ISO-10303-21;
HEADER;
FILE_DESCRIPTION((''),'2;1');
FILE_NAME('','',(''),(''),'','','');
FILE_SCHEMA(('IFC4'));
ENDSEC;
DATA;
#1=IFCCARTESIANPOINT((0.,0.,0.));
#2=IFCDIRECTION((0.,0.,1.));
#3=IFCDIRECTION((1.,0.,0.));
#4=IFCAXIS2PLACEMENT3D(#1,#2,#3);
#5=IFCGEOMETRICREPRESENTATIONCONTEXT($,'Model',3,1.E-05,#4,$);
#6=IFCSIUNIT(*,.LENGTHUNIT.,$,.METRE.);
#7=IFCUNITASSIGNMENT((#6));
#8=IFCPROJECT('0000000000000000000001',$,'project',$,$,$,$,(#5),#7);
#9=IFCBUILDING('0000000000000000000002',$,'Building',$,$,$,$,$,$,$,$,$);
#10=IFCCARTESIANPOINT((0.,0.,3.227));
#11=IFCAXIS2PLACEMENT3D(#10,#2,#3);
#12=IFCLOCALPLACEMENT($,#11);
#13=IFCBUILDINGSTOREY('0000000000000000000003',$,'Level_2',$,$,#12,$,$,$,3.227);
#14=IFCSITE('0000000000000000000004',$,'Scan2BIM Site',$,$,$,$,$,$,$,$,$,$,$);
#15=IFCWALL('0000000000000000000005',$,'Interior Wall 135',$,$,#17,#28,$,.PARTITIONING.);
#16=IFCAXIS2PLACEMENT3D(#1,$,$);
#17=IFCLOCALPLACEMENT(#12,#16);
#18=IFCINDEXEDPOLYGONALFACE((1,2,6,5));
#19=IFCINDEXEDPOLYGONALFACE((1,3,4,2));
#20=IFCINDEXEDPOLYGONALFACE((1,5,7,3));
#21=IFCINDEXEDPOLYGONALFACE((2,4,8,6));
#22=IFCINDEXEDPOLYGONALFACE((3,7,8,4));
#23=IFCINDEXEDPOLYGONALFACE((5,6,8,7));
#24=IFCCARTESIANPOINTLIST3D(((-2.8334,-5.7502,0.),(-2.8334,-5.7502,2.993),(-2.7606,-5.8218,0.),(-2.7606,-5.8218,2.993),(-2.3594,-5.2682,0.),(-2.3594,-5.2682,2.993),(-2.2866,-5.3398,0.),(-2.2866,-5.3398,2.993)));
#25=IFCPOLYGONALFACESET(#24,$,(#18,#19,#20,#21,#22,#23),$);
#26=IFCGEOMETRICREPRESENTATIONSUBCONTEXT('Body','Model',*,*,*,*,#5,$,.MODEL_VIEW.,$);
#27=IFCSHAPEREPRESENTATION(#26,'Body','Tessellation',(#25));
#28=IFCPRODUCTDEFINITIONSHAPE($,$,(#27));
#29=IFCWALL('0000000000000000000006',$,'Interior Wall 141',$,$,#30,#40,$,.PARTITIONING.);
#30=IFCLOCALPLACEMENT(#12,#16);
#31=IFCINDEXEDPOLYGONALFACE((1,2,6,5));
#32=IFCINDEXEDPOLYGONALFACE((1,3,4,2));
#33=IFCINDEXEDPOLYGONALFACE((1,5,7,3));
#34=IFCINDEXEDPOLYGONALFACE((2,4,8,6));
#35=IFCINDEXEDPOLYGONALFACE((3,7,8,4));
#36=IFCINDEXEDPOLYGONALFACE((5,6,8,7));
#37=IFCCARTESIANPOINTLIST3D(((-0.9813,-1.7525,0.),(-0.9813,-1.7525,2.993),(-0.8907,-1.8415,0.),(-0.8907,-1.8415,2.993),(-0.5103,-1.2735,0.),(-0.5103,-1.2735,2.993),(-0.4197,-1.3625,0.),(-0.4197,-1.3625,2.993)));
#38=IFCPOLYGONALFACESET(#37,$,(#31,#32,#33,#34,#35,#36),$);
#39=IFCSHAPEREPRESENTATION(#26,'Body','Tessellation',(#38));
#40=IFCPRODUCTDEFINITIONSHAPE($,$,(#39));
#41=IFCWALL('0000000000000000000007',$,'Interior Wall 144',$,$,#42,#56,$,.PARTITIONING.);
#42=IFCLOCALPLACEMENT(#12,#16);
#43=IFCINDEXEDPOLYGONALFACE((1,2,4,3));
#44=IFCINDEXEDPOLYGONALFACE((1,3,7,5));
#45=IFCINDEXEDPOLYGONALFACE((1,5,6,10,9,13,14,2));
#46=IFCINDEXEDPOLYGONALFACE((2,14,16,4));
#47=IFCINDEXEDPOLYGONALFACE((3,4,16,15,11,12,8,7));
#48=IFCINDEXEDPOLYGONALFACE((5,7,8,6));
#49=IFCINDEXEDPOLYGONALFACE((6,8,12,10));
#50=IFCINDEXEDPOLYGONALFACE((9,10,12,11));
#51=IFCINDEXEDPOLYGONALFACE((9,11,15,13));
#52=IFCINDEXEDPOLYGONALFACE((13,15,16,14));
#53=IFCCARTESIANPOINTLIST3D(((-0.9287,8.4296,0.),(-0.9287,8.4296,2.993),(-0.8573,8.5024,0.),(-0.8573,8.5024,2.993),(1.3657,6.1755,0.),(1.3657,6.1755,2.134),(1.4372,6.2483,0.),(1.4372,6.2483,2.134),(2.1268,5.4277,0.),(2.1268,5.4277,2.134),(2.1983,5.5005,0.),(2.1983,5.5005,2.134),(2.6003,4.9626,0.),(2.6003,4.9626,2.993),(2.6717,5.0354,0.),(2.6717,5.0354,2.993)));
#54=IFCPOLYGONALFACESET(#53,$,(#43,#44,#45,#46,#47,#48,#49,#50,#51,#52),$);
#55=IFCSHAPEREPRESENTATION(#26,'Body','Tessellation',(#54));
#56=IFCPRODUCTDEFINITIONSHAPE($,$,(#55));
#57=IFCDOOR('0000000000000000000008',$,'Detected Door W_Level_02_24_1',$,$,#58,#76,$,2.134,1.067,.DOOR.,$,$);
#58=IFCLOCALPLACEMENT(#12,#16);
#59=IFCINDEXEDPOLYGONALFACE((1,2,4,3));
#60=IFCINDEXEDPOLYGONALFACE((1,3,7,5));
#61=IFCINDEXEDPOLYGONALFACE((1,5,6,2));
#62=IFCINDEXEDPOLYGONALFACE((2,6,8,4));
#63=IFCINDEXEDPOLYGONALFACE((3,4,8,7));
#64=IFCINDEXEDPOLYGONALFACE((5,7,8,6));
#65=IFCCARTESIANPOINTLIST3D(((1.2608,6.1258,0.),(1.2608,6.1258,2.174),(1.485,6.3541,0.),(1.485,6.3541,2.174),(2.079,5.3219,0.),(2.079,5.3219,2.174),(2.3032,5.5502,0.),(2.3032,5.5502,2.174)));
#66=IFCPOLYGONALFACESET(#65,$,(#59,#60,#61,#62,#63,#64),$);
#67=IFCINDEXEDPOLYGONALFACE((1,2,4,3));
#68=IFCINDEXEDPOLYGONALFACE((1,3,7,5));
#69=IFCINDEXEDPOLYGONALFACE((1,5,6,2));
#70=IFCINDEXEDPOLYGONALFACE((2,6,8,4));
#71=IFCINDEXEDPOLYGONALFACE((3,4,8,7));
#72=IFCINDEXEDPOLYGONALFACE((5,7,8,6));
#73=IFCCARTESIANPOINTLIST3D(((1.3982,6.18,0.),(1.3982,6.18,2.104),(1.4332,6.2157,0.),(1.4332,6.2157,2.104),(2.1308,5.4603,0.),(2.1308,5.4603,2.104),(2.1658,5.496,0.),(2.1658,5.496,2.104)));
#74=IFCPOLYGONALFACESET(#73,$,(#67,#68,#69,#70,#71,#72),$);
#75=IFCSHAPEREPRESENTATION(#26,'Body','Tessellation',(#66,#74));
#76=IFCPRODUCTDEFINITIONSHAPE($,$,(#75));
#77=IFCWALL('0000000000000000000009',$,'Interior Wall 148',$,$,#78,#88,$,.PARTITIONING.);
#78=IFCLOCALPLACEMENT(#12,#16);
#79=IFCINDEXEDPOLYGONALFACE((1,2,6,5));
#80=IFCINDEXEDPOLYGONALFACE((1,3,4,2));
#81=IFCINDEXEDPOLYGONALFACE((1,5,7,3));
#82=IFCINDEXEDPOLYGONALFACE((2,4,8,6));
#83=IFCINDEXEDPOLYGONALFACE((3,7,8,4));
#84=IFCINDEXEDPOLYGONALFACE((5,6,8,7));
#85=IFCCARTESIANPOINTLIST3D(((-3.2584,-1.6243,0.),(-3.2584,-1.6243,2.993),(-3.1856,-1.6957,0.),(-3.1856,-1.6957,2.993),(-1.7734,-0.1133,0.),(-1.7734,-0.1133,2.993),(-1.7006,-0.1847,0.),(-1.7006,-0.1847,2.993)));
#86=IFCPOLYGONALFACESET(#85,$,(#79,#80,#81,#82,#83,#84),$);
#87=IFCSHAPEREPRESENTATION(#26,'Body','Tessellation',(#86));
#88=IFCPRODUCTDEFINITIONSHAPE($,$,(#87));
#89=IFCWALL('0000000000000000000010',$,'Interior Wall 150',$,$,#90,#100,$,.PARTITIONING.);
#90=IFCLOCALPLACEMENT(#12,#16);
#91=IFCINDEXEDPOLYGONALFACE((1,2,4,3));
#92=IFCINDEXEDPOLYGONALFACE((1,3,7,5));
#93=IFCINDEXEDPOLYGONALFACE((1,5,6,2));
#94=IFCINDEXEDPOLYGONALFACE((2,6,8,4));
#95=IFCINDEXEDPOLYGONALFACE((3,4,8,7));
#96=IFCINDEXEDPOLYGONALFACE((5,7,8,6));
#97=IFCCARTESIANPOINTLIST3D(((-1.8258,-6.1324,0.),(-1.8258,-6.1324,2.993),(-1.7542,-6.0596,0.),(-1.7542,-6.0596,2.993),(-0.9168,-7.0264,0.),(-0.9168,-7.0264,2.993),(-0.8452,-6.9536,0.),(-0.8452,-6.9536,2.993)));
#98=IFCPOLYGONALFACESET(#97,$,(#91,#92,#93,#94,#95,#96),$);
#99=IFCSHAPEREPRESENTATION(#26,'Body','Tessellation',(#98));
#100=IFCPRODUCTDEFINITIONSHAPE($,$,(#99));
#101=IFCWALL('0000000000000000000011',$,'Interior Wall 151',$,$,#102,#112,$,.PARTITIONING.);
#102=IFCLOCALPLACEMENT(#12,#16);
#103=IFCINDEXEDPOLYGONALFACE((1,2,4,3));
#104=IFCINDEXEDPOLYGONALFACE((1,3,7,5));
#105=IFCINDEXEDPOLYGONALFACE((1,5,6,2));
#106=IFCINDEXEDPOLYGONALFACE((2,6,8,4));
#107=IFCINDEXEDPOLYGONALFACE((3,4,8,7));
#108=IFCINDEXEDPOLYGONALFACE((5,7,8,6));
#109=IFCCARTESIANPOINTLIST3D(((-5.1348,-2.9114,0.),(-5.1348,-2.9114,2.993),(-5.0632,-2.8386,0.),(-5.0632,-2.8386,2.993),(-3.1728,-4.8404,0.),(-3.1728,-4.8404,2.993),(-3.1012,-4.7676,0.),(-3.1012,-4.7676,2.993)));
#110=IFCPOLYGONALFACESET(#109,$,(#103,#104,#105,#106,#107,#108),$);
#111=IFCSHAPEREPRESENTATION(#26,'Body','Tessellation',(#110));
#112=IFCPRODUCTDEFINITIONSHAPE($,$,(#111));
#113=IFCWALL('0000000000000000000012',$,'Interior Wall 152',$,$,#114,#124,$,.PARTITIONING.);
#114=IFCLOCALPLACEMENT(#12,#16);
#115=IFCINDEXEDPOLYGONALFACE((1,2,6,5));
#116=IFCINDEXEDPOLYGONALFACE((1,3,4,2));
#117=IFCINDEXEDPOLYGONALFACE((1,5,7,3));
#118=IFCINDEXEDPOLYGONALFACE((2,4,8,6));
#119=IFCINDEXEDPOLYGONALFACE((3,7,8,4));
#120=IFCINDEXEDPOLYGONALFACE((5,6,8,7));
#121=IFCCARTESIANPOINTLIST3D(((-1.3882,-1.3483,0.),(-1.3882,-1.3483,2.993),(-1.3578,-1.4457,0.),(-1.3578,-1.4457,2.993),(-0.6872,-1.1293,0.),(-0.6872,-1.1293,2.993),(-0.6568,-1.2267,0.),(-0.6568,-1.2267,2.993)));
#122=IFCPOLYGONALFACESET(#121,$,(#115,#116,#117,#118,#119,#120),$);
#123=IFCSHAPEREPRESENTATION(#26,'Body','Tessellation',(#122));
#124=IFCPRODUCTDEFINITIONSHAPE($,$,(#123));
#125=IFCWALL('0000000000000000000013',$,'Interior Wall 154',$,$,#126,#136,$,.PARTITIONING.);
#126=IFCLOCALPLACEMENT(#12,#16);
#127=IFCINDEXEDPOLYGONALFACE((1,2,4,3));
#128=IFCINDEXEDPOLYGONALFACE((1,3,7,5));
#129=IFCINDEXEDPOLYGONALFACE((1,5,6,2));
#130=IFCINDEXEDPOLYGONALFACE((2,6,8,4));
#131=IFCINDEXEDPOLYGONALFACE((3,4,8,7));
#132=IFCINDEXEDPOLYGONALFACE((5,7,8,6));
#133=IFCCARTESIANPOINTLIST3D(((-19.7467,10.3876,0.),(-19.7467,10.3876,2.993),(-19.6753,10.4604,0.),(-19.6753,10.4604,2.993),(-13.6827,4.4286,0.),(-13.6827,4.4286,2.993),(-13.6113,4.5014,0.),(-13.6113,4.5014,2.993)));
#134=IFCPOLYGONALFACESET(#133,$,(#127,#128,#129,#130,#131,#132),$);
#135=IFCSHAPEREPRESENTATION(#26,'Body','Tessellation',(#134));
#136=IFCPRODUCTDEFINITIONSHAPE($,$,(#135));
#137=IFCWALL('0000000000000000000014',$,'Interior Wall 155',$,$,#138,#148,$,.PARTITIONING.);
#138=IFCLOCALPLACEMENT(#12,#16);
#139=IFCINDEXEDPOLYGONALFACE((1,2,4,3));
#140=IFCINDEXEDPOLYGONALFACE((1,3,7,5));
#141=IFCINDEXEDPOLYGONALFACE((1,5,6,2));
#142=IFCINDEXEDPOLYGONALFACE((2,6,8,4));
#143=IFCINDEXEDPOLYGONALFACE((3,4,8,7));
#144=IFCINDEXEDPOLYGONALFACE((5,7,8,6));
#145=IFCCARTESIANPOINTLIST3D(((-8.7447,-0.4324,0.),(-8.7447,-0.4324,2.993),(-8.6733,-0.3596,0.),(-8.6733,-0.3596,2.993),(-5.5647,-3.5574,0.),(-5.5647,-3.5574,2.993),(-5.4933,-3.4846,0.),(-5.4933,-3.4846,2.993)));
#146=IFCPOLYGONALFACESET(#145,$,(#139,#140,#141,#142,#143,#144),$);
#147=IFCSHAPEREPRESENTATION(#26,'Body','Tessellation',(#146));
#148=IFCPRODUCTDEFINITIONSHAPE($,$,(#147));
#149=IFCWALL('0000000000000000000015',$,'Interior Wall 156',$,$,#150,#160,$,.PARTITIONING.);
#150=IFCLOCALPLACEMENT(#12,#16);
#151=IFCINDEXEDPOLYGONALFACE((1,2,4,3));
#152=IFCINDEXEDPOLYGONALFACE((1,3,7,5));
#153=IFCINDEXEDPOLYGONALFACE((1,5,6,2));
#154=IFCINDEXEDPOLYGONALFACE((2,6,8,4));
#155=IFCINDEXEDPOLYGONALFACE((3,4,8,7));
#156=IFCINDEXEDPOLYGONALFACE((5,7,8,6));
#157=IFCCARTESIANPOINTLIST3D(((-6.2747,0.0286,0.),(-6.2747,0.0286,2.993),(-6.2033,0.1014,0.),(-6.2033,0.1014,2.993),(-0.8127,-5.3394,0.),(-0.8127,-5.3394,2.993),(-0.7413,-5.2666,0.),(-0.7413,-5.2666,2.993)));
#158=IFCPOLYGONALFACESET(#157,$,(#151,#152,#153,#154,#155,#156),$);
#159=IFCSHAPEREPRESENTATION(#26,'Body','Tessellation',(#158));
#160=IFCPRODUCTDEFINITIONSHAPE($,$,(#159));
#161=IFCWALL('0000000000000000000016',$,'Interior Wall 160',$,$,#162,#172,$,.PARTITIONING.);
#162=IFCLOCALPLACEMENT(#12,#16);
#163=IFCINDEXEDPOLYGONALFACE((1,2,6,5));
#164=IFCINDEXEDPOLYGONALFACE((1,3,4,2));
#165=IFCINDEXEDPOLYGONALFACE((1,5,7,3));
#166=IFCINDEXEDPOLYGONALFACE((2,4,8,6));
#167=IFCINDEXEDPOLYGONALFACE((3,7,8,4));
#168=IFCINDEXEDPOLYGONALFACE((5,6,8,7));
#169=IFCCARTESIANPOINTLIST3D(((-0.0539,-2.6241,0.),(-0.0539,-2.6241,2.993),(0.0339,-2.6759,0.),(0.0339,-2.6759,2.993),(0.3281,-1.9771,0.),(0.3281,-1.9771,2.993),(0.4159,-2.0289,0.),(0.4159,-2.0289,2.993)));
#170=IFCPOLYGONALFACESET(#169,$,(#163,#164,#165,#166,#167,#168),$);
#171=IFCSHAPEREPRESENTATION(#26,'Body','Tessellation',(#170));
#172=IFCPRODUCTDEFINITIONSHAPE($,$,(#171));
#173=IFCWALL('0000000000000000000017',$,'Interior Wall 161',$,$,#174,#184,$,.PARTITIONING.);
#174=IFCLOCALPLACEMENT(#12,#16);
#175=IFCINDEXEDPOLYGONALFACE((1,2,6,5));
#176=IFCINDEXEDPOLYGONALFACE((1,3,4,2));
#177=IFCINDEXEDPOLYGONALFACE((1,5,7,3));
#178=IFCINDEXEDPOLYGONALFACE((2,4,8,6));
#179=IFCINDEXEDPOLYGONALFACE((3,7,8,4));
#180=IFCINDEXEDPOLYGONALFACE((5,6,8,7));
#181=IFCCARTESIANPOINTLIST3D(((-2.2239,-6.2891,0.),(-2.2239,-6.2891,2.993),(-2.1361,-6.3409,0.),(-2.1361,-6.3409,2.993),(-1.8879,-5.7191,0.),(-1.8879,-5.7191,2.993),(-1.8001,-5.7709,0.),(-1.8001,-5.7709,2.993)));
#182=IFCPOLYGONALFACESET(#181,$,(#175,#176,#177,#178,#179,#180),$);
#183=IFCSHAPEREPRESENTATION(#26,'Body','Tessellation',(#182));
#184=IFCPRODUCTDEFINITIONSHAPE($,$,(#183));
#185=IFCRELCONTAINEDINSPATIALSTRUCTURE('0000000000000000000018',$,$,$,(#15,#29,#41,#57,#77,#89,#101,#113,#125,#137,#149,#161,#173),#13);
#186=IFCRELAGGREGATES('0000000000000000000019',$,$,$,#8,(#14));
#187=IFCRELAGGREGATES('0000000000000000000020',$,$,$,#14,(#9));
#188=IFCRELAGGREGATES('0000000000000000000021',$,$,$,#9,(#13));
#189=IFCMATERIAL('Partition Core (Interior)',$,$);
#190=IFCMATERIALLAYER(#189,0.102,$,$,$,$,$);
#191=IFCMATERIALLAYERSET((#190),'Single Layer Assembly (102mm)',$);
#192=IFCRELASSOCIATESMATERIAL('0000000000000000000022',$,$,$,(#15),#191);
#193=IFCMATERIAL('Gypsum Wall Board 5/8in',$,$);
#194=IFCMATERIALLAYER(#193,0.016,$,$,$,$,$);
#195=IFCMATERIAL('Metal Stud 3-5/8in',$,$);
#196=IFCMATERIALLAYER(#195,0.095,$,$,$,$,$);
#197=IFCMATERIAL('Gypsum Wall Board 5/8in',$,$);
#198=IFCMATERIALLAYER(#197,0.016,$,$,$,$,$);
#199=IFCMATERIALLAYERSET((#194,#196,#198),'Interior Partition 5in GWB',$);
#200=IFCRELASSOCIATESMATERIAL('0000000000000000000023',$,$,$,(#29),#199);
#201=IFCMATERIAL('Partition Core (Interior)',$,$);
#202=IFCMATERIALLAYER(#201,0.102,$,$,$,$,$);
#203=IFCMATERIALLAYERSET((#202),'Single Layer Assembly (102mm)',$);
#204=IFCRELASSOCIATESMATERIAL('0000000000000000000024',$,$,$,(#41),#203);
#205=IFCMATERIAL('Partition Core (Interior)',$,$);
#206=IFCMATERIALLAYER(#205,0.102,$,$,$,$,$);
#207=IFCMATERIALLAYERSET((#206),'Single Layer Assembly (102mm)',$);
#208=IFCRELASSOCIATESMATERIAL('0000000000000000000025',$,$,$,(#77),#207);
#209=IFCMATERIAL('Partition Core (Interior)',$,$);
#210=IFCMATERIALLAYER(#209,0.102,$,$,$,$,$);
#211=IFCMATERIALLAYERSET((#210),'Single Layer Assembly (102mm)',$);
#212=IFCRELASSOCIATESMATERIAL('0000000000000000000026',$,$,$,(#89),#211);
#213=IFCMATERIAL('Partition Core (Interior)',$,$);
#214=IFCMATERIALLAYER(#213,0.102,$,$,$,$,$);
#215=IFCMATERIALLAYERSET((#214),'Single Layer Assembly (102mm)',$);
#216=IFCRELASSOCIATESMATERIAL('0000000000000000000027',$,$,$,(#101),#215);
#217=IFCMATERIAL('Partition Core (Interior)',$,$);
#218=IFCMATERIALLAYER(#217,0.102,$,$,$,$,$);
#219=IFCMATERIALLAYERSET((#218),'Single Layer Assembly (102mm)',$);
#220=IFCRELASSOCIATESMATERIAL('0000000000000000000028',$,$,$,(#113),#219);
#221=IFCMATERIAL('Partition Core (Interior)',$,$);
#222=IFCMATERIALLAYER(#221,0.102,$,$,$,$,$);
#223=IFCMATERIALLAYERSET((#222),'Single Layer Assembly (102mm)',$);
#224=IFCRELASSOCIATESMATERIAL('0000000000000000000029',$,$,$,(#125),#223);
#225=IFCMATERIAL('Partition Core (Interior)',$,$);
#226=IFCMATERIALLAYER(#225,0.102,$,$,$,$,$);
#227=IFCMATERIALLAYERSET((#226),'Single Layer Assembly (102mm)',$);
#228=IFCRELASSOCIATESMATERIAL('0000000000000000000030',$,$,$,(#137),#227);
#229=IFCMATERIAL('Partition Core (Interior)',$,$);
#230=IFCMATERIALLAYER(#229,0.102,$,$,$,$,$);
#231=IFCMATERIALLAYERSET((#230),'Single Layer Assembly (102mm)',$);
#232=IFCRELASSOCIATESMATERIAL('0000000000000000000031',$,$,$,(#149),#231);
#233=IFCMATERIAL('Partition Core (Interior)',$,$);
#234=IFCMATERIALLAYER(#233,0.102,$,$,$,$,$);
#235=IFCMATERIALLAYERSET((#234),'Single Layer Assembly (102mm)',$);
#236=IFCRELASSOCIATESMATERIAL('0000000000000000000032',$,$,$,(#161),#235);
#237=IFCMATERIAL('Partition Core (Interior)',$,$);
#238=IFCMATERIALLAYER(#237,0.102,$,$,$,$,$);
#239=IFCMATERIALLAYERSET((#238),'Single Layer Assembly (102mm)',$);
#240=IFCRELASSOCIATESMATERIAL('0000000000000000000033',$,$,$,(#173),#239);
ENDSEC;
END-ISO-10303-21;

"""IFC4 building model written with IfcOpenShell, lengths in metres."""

from ifc_helpers import new_model, si_unit, frame, origin, origin_with_axes, place, context, subcontext, project, spatial, rectangle, extrude, material, layer, layer_set, element, fill, save


model = new_model("IFC4")

# Units and contexts
model_context = context("Model", 3, precision=1e-05, world=origin_with_axes())
body_context = subcontext(model_context, "Body", "Model", "MODEL_VIEW")
ifc_project = project(units=[si_unit("LENGTHUNIT", "METRE")], contexts=[model_context])

# Site, building, storey
site = spatial("IfcSite", under=ifc_project, Name="Scan2BIM Site")
building = spatial("IfcBuilding", under=site, Name="Building")
storey_placement = place(None, frame((0.0, 0.0, 3.227), z_axis=(0.0, 0.0, 1.0), x_axis=(1.0, 0.0, 0.0)))
storey = spatial("IfcBuildingStorey", under=building, at=storey_placement, Name="Level_2", Elevation=3.227)

# Walls
ifc_material_1 = material(Name="Partition Core (Interior)")
ifc_layer_1 = layer(ifc_material_1, 0.102)
ifc_layer_set_1 = layer_set([ifc_layer_1], Name="Single Layer Assembly (102mm)")
wall_1_placement = place(storey_placement, frame((-2.56, -5.545, 0.0), z_axis=(0.0, 0.0, 1.0), x_axis=(0.701165, 0.712999, 0.0)))
element("IfcWall", 1, at=wall_1_placement, inside=storey, material=ifc_layer_set_1, Name="Interior Wall 135", PredefinedType="PARTITIONING", context=body_context, shape_type="SweptSolid", body=[
    extrude(rectangle(XDim=0.676, YDim=0.102), origin(), (0.0, 0.0, 1.0), 2.993),
])
ifc_material_2 = material(Name="Gypsum Wall Board 5/8in")
ifc_layer_2 = layer(ifc_material_2, 0.016)
ifc_material_3 = material(Name="Metal Stud 3-5/8in")
ifc_layer_3 = layer(ifc_material_3, 0.095)
ifc_material_4 = material(Name="Gypsum Wall Board 5/8in")
ifc_layer_4 = layer(ifc_material_4, 0.016)
ifc_layer_set_2 = layer_set([ifc_layer_2, ifc_layer_3, ifc_layer_4], Name="Interior Partition 5in GWB")
wall_2_placement = place(storey_placement, frame((-0.7005, -1.5575, 0.0), z_axis=(0.0, 0.0, 1.0), x_axis=(-0.701127, -0.713036, 0.0)))
element("IfcWall", 2, at=wall_2_placement, inside=storey, material=ifc_layer_set_2, Name="Interior Wall 141", PredefinedType="PARTITIONING", context=body_context, shape_type="SweptSolid", body=[
    extrude(rectangle(XDim=0.6718, YDim=0.127), origin(), (0.0, 0.0, 1.0), 2.993),
])

# Wall, opening, door
ifc_material_5 = material(Name="Partition Core (Interior)")
ifc_layer_5 = layer(ifc_material_5, 0.102)
ifc_layer_set_3 = layer_set([ifc_layer_5], Name="Single Layer Assembly (102mm)")
wall_3_placement = place(storey_placement, frame((0.8715, 6.7325, 0.0), z_axis=(0.0, 0.0, 1.0), x_axis=(0.713345, -0.700813, 0.0)))
wall_3 = element("IfcWall", 3, at=wall_3_placement, inside=storey, material=ifc_layer_set_3, Name="Interior Wall 144", PredefinedType="PARTITIONING", context=body_context, shape_type="SweptSolid", body=[
    extrude(rectangle(XDim=4.9471, YDim=0.102), origin(), (0.0, 0.0, 1.0), 2.993),
])
opening_1_placement = place(None, frame((1.782, 5.838, 3.227), z_axis=(0.0, 0.0, 1.0), x_axis=(0.713345, -0.700813, 0.0)))
opening_1 = element("IfcOpeningElement", 4, at=opening_1_placement, cuts=wall_3, PredefinedType="OPENING", context=body_context, shape_type="SweptSolid", body=[
    extrude(rectangle(XDim=1.067, YDim=0.202), origin(), (0.0, 0.0, 1.0), 2.134),
])
door_1_placement = place(opening_1_placement, frame((0.0, 0.0, 0.0), z_axis=(0.0, 0.0, 1.0), x_axis=(1.0, 0.0, 0.0)))
door_1 = element("IfcDoor", 5, at=door_1_placement, inside=storey, Name="Detected Door W_Level_02_24_1", OverallHeight=2.134, OverallWidth=1.067, PredefinedType="DOOR", context=body_context, shape_type="SweptSolid", body=[
    extrude(rectangle(XDim=1.147, YDim=0.32), origin(), (0.0, 0.0, 1.0), 2.174),
    extrude(rectangle(XDim=1.027, YDim=0.05), origin(), (0.0, 0.0, 1.0), 2.104),
])
fill(opening_1, door_1)

# Walls
ifc_material_6 = material(Name="Partition Core (Interior)")
ifc_layer_6 = layer(ifc_material_6, 0.102)
ifc_layer_set_4 = layer_set([ifc_layer_6], Name="Single Layer Assembly (102mm)")
wall_4_placement = place(storey_placement, frame((-2.4795, -0.9045, 0.0), z_axis=(0.0, 0.0, 1.0), x_axis=(0.700944, 0.713216, 0.0)))
element("IfcWall", 6, at=wall_4_placement, inside=storey, material=ifc_layer_set_4, Name="Interior Wall 148", PredefinedType="PARTITIONING", context=body_context, shape_type="SweptSolid", body=[
    extrude(rectangle(XDim=2.1186, YDim=0.102), origin(), (0.0, 0.0, 1.0), 2.993),
])
ifc_material_7 = material(Name="Partition Core (Interior)")
ifc_layer_7 = layer(ifc_material_7, 0.102)
ifc_layer_set_5 = layer_set([ifc_layer_7], Name="Single Layer Assembly (102mm)")
wall_5_placement = place(storey_placement, frame((-1.3355, -6.543, 0.0), z_axis=(0.0, 0.0, 1.0), x_axis=(-0.712965, 0.7012, 0.0)))
element("IfcWall", 7, at=wall_5_placement, inside=storey, material=ifc_layer_set_5, Name="Interior Wall 150", PredefinedType="PARTITIONING", context=body_context, shape_type="SweptSolid", body=[
    extrude(rectangle(XDim=1.275, YDim=0.102), origin(), (0.0, 0.0, 1.0), 2.993),
])
ifc_material_8 = material(Name="Partition Core (Interior)")
ifc_layer_8 = layer(ifc_material_8, 0.102)
ifc_layer_set_6 = layer_set([ifc_layer_8], Name="Single Layer Assembly (102mm)")
wall_6_placement = place(storey_placement, frame((-4.118, -3.8395, 0.0), z_axis=(0.0, 0.0, 1.0), x_axis=(-0.713078, 0.701085, 0.0)))
element("IfcWall", 8, at=wall_6_placement, inside=storey, material=ifc_layer_set_6, Name="Interior Wall 151", PredefinedType="PARTITIONING", context=body_context, shape_type="SweptSolid", body=[
    extrude(rectangle(XDim=2.7515, YDim=0.102), origin(), (0.0, 0.0, 1.0), 2.993),
])
ifc_material_9 = material(Name="Partition Core (Interior)")
ifc_layer_9 = layer(ifc_material_9, 0.102)
ifc_layer_set_7 = layer_set([ifc_layer_9], Name="Single Layer Assembly (102mm)")
wall_7_placement = place(storey_placement, frame((-1.0225, -1.2875, 0.0), z_axis=(0.0, 0.0, 1.0), x_axis=(0.954504, 0.298197, 0.0)))
element("IfcWall", 9, at=wall_7_placement, inside=storey, material=ifc_layer_set_7, Name="Interior Wall 152", PredefinedType="PARTITIONING", context=body_context, shape_type="SweptSolid", body=[
    extrude(rectangle(XDim=0.7344, YDim=0.102), origin(), (0.0, 0.0, 1.0), 2.993),
])
ifc_material_10 = material(Name="Partition Core (Interior)")
ifc_layer_10 = layer(ifc_material_10, 0.102)
ifc_layer_set_8 = layer_set([ifc_layer_10], Name="Single Layer Assembly (102mm)")
wall_8_placement = place(storey_placement, frame((-16.679, 7.4445, 0.0), z_axis=(0.0, 0.0, 1.0), x_axis=(0.713255, -0.700905, 0.0)))
element("IfcWall", 10, at=wall_8_placement, inside=storey, material=ifc_layer_set_8, Name="Interior Wall 154", PredefinedType="PARTITIONING", context=body_context, shape_type="SweptSolid", body=[
    extrude(rectangle(XDim=8.5019, YDim=0.102), origin(), (0.0, 0.0, 1.0), 2.993),
])
ifc_material_11 = material(Name="Partition Core (Interior)")
ifc_layer_11 = layer(ifc_material_11, 0.102)
ifc_layer_set_9 = layer_set([ifc_layer_11], Name="Single Layer Assembly (102mm)")
wall_9_placement = place(storey_placement, frame((-7.119, -1.9585, 0.0), z_axis=(0.0, 0.0, 1.0), x_axis=(0.713248, -0.700912, 0.0)))
element("IfcWall", 11, at=wall_9_placement, inside=storey, material=ifc_layer_set_9, Name="Interior Wall 155", PredefinedType="PARTITIONING", context=body_context, shape_type="SweptSolid", body=[
    extrude(rectangle(XDim=4.4585, YDim=0.102), origin(), (0.0, 0.0, 1.0), 2.993),
])
ifc_material_12 = material(Name="Partition Core (Interior)")
ifc_layer_12 = layer(ifc_material_12, 0.102)
ifc_layer_set_10 = layer_set([ifc_layer_12], Name="Single Layer Assembly (102mm)")
wall_10_placement = place(storey_placement, frame((-3.508, -2.619, 0.0), z_axis=(0.0, 0.0, 1.0), x_axis=(0.713217, -0.700943, 0.0)))
element("IfcWall", 12, at=wall_10_placement, inside=storey, material=ifc_layer_set_10, Name="Interior Wall 156", PredefinedType="PARTITIONING", context=body_context, shape_type="SweptSolid", body=[
    extrude(rectangle(XDim=7.6583, YDim=0.102), origin(), (0.0, 0.0, 1.0), 2.993),
])
ifc_material_13 = material(Name="Partition Core (Interior)")
ifc_layer_13 = layer(ifc_material_13, 0.102)
ifc_layer_set_11 = layer_set([ifc_layer_13], Name="Single Layer Assembly (102mm)")
wall_11_placement = place(storey_placement, frame((0.181, -2.3265, 0.0), z_axis=(0.0, 0.0, 1.0), x_axis=(-0.508415, -0.861112, 0.0)))
element("IfcWall", 13, at=wall_11_placement, inside=storey, material=ifc_layer_set_11, Name="Interior Wall 160", PredefinedType="PARTITIONING", context=body_context, shape_type="SweptSolid", body=[
    extrude(rectangle(XDim=0.7514, YDim=0.102), origin(), (0.0, 0.0, 1.0), 2.993),
])
ifc_material_14 = material(Name="Partition Core (Interior)")
ifc_layer_14 = layer(ifc_material_14, 0.102)
ifc_layer_set_12 = layer_set([ifc_layer_14], Name="Single Layer Assembly (102mm)")
wall_12_placement = place(storey_placement, frame((-2.012, -6.03, 0.0), z_axis=(0.0, 0.0, 1.0), x_axis=(-0.507812, -0.861468, 0.0)))
element("IfcWall", 14, at=wall_12_placement, inside=storey, material=ifc_layer_set_12, Name="Interior Wall 161", PredefinedType="PARTITIONING", context=body_context, shape_type="SweptSolid", body=[
    extrude(rectangle(XDim=0.6617, YDim=0.102), origin(), (0.0, 0.0, 1.0), 2.993),
])

save(model, "model.ifc")
